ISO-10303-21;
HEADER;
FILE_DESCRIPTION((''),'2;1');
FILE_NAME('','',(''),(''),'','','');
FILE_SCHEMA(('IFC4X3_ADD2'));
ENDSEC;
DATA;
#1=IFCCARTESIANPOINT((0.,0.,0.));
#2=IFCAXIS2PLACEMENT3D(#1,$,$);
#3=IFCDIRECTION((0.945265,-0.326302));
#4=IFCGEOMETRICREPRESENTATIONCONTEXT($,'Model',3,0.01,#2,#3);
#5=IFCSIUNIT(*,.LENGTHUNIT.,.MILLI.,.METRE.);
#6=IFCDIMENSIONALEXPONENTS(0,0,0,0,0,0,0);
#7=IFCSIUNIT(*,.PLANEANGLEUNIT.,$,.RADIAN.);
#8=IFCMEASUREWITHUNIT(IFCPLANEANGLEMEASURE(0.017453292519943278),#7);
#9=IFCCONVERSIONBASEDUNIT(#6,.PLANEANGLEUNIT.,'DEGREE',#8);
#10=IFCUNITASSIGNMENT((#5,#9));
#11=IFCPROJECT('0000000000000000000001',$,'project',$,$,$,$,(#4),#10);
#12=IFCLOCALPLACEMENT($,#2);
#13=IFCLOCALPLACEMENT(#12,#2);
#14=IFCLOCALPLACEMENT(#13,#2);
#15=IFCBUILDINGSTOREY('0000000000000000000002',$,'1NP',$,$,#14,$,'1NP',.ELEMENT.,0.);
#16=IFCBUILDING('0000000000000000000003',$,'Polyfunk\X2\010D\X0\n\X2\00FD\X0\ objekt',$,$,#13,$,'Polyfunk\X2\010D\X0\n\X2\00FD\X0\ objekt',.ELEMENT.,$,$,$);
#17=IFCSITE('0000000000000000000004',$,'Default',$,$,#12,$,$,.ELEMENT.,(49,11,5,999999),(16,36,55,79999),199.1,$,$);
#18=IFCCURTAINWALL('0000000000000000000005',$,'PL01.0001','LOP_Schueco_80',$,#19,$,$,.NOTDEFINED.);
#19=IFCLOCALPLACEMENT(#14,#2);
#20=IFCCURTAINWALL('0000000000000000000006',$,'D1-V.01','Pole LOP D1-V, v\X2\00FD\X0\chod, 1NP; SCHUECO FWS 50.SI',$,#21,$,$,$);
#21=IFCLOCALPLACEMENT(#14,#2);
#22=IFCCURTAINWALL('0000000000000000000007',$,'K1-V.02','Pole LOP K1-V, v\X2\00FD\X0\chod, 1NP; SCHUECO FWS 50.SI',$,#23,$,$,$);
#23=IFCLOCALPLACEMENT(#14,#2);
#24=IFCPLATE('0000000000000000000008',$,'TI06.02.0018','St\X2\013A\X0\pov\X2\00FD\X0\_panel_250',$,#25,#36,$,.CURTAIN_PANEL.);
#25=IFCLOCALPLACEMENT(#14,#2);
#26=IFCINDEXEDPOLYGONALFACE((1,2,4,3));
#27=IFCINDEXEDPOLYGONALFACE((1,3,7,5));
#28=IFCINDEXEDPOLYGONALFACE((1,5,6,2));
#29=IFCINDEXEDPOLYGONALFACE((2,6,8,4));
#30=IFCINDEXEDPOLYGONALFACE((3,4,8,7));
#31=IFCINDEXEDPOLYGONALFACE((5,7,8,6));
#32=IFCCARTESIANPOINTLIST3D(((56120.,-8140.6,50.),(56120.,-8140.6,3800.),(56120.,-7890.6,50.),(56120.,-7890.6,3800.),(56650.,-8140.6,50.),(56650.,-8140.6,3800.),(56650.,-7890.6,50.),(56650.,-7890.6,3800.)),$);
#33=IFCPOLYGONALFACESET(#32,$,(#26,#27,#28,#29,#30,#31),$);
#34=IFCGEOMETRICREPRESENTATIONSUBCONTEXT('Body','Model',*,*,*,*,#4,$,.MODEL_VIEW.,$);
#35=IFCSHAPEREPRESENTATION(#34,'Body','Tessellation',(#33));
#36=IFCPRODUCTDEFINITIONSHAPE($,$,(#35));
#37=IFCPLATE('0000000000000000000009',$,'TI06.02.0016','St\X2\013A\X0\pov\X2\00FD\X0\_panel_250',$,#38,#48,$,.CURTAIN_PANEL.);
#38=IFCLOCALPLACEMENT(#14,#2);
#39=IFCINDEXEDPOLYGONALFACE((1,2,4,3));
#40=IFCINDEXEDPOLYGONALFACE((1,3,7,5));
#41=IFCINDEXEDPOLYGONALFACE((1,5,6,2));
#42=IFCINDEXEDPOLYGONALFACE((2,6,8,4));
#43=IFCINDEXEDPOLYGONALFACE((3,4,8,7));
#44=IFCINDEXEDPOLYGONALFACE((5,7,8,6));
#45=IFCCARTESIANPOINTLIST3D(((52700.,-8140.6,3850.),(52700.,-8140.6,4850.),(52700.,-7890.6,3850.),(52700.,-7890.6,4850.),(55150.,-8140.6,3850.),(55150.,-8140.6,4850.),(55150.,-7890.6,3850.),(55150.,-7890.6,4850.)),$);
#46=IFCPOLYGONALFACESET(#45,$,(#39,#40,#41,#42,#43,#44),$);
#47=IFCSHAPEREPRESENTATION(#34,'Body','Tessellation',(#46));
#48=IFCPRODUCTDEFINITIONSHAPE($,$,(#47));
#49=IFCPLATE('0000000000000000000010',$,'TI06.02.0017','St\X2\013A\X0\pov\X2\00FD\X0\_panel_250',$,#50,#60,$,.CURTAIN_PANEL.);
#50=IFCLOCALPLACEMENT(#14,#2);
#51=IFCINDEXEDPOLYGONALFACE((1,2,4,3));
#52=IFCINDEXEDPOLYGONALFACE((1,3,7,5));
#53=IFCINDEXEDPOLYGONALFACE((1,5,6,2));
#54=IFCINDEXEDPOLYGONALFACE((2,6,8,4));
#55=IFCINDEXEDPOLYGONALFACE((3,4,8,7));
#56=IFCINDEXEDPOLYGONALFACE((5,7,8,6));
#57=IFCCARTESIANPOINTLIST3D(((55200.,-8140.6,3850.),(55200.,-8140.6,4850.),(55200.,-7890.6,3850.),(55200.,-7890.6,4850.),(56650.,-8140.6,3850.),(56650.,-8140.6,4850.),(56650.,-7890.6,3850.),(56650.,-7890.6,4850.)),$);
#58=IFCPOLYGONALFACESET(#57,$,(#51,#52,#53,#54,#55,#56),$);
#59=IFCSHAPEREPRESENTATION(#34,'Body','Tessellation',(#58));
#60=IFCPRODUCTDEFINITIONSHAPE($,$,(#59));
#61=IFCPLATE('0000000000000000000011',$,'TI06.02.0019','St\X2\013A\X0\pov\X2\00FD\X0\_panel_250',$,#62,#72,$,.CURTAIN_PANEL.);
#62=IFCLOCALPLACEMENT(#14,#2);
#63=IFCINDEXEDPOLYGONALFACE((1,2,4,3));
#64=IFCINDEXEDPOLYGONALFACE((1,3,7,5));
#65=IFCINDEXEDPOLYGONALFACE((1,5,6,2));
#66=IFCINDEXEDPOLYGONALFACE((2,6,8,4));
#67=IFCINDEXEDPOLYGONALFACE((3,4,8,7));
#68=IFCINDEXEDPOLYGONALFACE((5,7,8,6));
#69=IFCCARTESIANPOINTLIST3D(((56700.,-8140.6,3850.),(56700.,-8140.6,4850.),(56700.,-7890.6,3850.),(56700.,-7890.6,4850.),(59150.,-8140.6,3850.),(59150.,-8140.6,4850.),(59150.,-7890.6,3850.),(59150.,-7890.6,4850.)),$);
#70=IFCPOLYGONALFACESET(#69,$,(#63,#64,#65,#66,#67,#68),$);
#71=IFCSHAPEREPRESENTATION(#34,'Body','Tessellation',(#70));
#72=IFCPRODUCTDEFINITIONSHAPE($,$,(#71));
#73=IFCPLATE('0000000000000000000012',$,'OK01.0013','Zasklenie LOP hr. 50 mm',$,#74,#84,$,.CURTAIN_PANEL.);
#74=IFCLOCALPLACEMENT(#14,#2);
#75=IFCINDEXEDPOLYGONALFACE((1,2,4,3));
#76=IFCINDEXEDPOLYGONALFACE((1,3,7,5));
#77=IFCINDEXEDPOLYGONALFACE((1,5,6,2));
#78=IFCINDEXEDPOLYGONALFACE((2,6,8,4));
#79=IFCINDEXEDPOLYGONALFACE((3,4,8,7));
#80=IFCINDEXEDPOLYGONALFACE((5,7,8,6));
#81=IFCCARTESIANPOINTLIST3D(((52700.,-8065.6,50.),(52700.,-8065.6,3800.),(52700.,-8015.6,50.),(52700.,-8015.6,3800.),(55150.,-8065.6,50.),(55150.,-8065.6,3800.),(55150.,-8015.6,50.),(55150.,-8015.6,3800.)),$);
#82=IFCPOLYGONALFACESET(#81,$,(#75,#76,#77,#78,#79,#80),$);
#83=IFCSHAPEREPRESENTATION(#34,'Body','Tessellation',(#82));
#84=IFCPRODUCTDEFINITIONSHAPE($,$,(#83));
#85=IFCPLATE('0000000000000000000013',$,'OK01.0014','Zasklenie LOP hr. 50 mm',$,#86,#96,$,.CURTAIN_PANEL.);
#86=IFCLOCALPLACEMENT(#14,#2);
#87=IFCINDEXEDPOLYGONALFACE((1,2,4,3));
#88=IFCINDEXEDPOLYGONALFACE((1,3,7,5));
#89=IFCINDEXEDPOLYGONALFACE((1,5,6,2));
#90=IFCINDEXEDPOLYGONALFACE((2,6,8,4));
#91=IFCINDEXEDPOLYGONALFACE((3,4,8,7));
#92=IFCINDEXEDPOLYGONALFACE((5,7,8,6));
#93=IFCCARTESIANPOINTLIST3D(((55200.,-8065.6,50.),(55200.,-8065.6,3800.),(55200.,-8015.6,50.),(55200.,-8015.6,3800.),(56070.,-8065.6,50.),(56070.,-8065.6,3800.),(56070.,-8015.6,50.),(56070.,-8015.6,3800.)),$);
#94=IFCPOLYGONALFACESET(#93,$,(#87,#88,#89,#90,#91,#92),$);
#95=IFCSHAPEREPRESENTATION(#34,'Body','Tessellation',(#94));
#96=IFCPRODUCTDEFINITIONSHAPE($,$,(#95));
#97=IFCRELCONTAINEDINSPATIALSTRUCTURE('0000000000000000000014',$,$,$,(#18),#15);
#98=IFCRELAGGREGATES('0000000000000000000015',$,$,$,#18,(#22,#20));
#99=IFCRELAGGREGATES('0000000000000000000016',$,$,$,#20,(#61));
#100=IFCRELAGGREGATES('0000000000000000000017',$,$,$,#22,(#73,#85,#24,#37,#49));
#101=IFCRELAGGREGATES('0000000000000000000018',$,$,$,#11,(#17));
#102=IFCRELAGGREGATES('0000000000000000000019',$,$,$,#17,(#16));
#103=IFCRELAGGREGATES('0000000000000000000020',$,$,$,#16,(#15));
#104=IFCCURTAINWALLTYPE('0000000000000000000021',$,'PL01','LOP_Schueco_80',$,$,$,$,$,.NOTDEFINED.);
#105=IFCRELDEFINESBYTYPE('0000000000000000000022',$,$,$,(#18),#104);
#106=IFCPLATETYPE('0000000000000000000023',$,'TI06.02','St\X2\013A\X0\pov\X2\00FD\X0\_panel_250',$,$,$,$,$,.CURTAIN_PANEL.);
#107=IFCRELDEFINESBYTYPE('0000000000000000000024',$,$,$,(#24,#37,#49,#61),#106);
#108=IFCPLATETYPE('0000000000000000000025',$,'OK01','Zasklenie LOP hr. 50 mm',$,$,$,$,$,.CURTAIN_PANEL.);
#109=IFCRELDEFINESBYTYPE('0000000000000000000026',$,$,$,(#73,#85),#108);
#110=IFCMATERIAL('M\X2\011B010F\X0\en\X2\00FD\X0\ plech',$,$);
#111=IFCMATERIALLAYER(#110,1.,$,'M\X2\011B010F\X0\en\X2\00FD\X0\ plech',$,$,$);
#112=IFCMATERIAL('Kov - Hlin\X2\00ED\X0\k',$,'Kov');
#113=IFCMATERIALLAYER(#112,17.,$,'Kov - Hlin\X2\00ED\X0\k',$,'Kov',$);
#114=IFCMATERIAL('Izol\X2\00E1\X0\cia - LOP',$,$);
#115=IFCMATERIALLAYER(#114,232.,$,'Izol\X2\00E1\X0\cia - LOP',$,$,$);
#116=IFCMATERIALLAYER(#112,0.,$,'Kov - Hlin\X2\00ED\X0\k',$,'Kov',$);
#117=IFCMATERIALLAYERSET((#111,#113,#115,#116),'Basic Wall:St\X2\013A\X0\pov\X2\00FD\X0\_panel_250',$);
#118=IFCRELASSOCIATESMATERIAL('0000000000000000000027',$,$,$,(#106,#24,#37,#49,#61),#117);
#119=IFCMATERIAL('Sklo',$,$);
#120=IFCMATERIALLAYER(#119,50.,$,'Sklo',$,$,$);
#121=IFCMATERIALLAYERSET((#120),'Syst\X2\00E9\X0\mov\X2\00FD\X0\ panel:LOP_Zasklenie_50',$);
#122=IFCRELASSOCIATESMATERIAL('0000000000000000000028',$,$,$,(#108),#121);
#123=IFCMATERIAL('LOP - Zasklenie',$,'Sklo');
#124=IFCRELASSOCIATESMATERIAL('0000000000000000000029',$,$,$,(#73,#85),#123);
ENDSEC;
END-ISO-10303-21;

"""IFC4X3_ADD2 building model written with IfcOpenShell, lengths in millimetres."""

from ifc_helpers import new_model, entity, si_unit, converted_unit, direction, frame, frame_2d, origin, origin_2d_with_axis, place, context, subcontext, project, spatial, rectangle, extrude, source, transform, mapped, material, layer, layer_set, layer_usage, type_object, type_shapes, element, aggregate, save


model = new_model("IFC4X3_ADD2")

# Units and contexts
model_context = context("Model", 3, precision=0.01, world=origin(), true_north=direction((0.945265, -0.326302)))
body_context = subcontext(model_context, "Body", "Model", "MODEL_VIEW")
ifc_project = project(units=[si_unit("LENGTHUNIT", "METRE", prefix="MILLI"), converted_unit("PLANEANGLEUNIT", "DEGREE", entity("IfcPlaneAngleMeasure", 0.017453292519943278), si_unit("PLANEANGLEUNIT", "RADIAN"), dimensions=[0, 0, 0, 0, 0, 0, 0])], contexts=[model_context])

# Site, building, storey
site_placement = place(None, origin())
site = spatial("IfcSite", under=ifc_project, at=site_placement, Name="Default", CompositionType="ELEMENT", RefLatitude=(49, 11, 5, 999999), RefLongitude=(16, 36, 55, 79999), RefElevation=199.1)
building_placement = place(site_placement, origin())
building = spatial("IfcBuilding", under=site, at=building_placement, Name="Polyfunkčný objekt", LongName="Polyfunkčný objekt", CompositionType="ELEMENT")
storey_placement = place(building_placement, origin())
storey = spatial("IfcBuildingStorey", under=building, at=storey_placement, Name="1NP", LongName="1NP", CompositionType="ELEMENT", Elevation=0.0)

# Curtain walls, plates
curtain_wall_type = type_object("IfcCurtainWallType", Name="PL01", Description="LOP_Schueco_80", PredefinedType="NOTDEFINED")
curtain_wall_1_placement = place(storey_placement, origin())
curtain_wall_1 = element("IfcCurtainWall", 1, at=curtain_wall_1_placement, inside=storey, type_object=curtain_wall_type, Name="PL01.0001", Description="LOP_Schueco_80", PredefinedType="NOTDEFINED")
curtain_wall_2 = element("IfcCurtainWall", 2, Name="D1-V.01", Description="Pole LOP D1-V, východ, 1NP; SCHUECO FWS 50.SI")
curtain_wall_3 = element("IfcCurtainWall", 3, Name="K1-V.02", Description="Pole LOP K1-V, východ, 1NP; SCHUECO FWS 50.SI")
aggregate(curtain_wall_1, [curtain_wall_3, curtain_wall_2])
ifc_material_1 = material(Name="Měďený plech")
ifc_layer_1 = layer(ifc_material_1, 1.0, Name="Měďený plech")
ifc_material_2 = material(Name="Kov - Hliník", Category="Kov")
ifc_layer_2 = layer(ifc_material_2, 17.0, Name="Kov - Hliník", Category="Kov")
ifc_material_3 = material(Name="Izolácia - LOP")
ifc_layer_3 = layer(ifc_material_3, 232.0, Name="Izolácia - LOP")
ifc_layer_4 = layer(ifc_material_2, 0.0, Name="Kov - Hliník", Category="Kov")
ifc_layer_set_1 = layer_set([ifc_layer_1, ifc_layer_2, ifc_layer_3, ifc_layer_4], Name="Basic Wall:Stĺpový_panel_250")
ifc_layer_usage_1 = layer_usage(ifc_layer_set_1, "AXIS2", "POSITIVE", -125.0)
plate_type_1 = type_object("IfcPlateType", Name="TI06.02", Description="Stĺpový_panel_250", PredefinedType="CURTAIN_PANEL", material=ifc_layer_set_1)
plate_1_placement = place(storey_placement, frame((56120.0, -8015.6, 50.0)))
plate_1 = element("IfcPlate", 4, at=plate_1_placement, type_object=plate_type_1, material=ifc_layer_usage_1, Name="TI06.02.0018", Description="Stĺpový_panel_250", PredefinedType="CURTAIN_PANEL", context=body_context, shape_type="SweptSolid", body=[
    extrude(rectangle(XDim=250.0, YDim=530.0, at=frame_2d((0.0, 0.0), x_axis=(1.0, 0.0))), frame((265.0, 0.0, 0.0), z_axis=(0.0, 0.0, 1.0), x_axis=(0.0, 1.0, 0.0)), (0.0, 0.0, 1.0), 3750.0),
])
ifc_layer_usage_2 = layer_usage(ifc_layer_set_1, "AXIS2", "POSITIVE", -125.0)
plate_2_placement = place(storey_placement, frame((52700.0, -8015.6, 3850.0)))
plate_2 = element("IfcPlate", 5, at=plate_2_placement, type_object=plate_type_1, material=ifc_layer_usage_2, Name="TI06.02.0016", Description="Stĺpový_panel_250", PredefinedType="CURTAIN_PANEL", context=body_context, shape_type="SweptSolid", body=[
    extrude(rectangle(XDim=250.0, YDim=2450.0, at=frame_2d((0.0, 0.0), x_axis=(1.0, 0.0))), frame((1225.0, 0.0, 0.0), z_axis=(0.0, 0.0, 1.0), x_axis=(0.0, 1.0, 0.0)), (0.0, 0.0, 1.0), 1000.0),
])
ifc_layer_usage_3 = layer_usage(ifc_layer_set_1, "AXIS2", "POSITIVE", -125.0)
plate_3_placement = place(storey_placement, frame((55200.0, -8015.6, 3850.0)))
plate_3 = element("IfcPlate", 6, at=plate_3_placement, type_object=plate_type_1, material=ifc_layer_usage_3, Name="TI06.02.0017", Description="Stĺpový_panel_250", PredefinedType="CURTAIN_PANEL", context=body_context, shape_type="SweptSolid", body=[
    extrude(rectangle(XDim=250.0, YDim=1450.0, at=frame_2d((0.0, 0.0), x_axis=(1.0, 0.0))), frame((725.0, 0.0, 0.0), z_axis=(0.0, 0.0, 1.0), x_axis=(0.0, 1.0, 0.0)), (0.0, 0.0, 1.0), 1000.0),
])
ifc_layer_usage_4 = layer_usage(ifc_layer_set_1, "AXIS2", "POSITIVE", -125.0)
plate_4_placement = place(storey_placement, frame((56700.0, -8015.6, 3850.0)))
plate_4 = element("IfcPlate", 7, at=plate_4_placement, type_object=plate_type_1, material=ifc_layer_usage_4, Name="TI06.02.0019", Description="Stĺpový_panel_250", PredefinedType="CURTAIN_PANEL", context=body_context, shape_type="SweptSolid", body=[
    extrude(rectangle(XDim=250.0, YDim=2450.0, at=origin_2d_with_axis()), frame((1225.0, 0.0, 0.0), z_axis=(0.0, 0.0, 1.0), x_axis=(0.0, 1.0, 0.0)), (0.0, 0.0, 1.0), 1000.0),
])
aggregate(curtain_wall_2, [plate_4])
ifc_material_4 = material(Name="LOP - Zasklenie", Category="Sklo")
ifc_material_5 = material(Name="Sklo")
ifc_layer_5 = layer(ifc_material_5, 50.0, Name="Sklo")
ifc_layer_set_2 = layer_set([ifc_layer_5], Name="Systémový panel:LOP_Zasklenie_50")
plate_type_2 = type_object("IfcPlateType", Name="OK01", Description="Zasklenie LOP hr. 50 mm", PredefinedType="CURTAIN_PANEL", material=ifc_layer_set_2)
shared_shape_1 = source(origin(), body_context, "Body", "SweptSolid", [
    extrude(rectangle(XDim=3750.0, YDim=2450.0, at=frame_2d((-331.2, 0.0), x_axis=(1.0, 0.0))), frame((0.0, -50.0, 2206.2), z_axis=(0.0, 1.0, 0.0), x_axis=(0.0, 0.0, 1.0)), (0.0, 0.0, 1.0), 50.0),
])
plate_5_placement = place(curtain_wall_1_placement, frame((53925.0, -8015.6, 50.0)))
plate_5 = element("IfcPlate", 8, at=plate_5_placement, type_object=plate_type_2, material=ifc_material_4, Name="OK01.0013", Description="Zasklenie LOP hr. 50 mm", PredefinedType="CURTAIN_PANEL", context=body_context, shape_type="MappedRepresentation", body=[
    mapped(shared_shape_1, transform((0.0, 0.0, 0.0), scale=1.0)),
])
shared_shape_2 = source(origin(), body_context, "Body", "SweptSolid", [
    extrude(rectangle(XDim=3750.0, YDim=870.0, at=frame_2d((-331.2, 0.0), x_axis=(1.0, 0.0))), frame((0.0, -50.0, 2206.2), z_axis=(0.0, 1.0, 0.0), x_axis=(0.0, 0.0, 1.0)), (0.0, 0.0, 1.0), 50.0),
])
type_shapes(plate_type_2, [shared_shape_1, shared_shape_2])
plate_6_placement = place(curtain_wall_1_placement, frame((55635.0, -8015.6, 50.0)))
plate_6 = element("IfcPlate", 9, at=plate_6_placement, type_object=plate_type_2, material=ifc_material_4, Name="OK01.0014", Description="Zasklenie LOP hr. 50 mm", PredefinedType="CURTAIN_PANEL", context=body_context, shape_type="MappedRepresentation", body=[
    mapped(shared_shape_2, transform((0.0, 0.0, 0.0), scale=1.0)),
])
aggregate(curtain_wall_3, [plate_5, plate_6, plate_1, plate_2, plate_3])

save(model, "model.ifc")
